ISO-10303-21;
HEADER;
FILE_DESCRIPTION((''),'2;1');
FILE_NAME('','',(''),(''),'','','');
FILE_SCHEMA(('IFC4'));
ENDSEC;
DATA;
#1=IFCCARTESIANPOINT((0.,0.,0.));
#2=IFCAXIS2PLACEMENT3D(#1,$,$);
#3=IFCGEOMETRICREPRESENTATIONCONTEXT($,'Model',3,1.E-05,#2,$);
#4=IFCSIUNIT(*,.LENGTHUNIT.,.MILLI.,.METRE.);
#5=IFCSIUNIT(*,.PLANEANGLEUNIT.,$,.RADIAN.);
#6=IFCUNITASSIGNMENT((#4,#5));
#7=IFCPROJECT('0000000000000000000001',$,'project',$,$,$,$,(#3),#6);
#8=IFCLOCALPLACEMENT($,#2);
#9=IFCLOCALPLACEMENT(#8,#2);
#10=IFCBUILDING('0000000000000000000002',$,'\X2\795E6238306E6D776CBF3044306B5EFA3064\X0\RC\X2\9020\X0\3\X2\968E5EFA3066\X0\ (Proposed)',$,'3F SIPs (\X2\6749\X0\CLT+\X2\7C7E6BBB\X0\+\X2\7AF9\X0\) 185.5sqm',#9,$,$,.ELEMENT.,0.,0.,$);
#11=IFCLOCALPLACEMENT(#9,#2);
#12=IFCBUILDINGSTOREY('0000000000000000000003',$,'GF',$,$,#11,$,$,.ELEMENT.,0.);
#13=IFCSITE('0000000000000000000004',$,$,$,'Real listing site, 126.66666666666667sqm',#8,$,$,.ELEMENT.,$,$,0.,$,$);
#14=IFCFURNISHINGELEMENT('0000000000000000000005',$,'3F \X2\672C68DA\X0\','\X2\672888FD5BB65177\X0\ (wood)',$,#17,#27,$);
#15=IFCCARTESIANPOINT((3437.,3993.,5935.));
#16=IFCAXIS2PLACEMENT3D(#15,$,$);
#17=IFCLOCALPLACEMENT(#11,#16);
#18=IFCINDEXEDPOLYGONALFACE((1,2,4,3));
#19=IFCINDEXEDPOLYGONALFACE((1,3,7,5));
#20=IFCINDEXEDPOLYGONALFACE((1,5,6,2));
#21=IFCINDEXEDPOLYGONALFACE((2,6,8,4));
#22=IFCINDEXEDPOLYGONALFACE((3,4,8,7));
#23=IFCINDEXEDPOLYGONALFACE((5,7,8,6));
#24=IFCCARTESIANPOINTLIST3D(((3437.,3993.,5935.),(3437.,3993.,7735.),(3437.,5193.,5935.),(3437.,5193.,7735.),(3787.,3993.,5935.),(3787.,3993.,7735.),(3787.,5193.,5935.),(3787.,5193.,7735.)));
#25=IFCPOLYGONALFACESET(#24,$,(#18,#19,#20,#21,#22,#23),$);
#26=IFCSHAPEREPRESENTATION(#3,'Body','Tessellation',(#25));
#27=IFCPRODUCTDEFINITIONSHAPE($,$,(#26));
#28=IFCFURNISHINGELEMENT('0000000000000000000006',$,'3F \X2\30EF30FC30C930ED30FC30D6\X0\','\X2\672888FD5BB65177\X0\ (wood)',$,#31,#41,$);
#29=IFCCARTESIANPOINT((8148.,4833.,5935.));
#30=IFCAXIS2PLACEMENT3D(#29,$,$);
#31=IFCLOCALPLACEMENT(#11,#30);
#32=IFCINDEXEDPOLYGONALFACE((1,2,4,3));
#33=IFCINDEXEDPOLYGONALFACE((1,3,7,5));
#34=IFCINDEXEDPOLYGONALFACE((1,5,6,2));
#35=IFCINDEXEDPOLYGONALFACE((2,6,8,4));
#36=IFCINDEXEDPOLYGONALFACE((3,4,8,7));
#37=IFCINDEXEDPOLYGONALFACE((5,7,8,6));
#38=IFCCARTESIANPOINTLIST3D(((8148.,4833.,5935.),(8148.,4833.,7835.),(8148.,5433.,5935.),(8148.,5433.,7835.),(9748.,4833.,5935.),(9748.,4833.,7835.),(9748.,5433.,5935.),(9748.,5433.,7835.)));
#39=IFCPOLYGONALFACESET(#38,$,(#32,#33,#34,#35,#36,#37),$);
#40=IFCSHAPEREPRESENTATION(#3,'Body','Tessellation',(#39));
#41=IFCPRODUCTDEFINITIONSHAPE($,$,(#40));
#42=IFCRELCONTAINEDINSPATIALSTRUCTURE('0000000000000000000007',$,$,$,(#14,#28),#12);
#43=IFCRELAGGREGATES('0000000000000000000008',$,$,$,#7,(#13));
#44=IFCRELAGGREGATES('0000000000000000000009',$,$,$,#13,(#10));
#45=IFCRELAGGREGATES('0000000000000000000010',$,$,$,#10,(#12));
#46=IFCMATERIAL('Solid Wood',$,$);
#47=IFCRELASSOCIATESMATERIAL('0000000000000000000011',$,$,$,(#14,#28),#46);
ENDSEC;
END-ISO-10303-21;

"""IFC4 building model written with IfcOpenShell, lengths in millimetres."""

from ifc_helpers import new_model, si_unit, frame, frame_2d, origin, place, context, project, spatial, rectangle, extrude, material, element, save


model = new_model("IFC4")

# Units and contexts
model_context = context("Model", 3, precision=1e-05, world=origin())
ifc_project = project(units=[si_unit("LENGTHUNIT", "METRE", prefix="MILLI"), si_unit("PLANEANGLEUNIT", "RADIAN")], contexts=[model_context])

# Site, building, storey
site_placement = place(None, origin())
site = spatial("IfcSite", under=ifc_project, at=site_placement, ObjectType="Real listing site, 126.66666666666667sqm", CompositionType="ELEMENT", RefElevation=0.0)
building_placement = place(site_placement, origin())
building = spatial("IfcBuilding", under=site, at=building_placement, Name="神戸の海沿いに建つRC造3階建て (Proposed)", ObjectType="3F SIPs (杉CLT+籾殻+竹) 185.5sqm", CompositionType="ELEMENT", ElevationOfRefHeight=0.0, ElevationOfTerrain=0.0)
storey_placement = place(building_placement, origin())
storey = spatial("IfcBuildingStorey", under=building, at=storey_placement, Name="GF", CompositionType="ELEMENT", Elevation=0.0)

# Shared definitions
ifc_material_1 = material(Name="Solid Wood")

# Furnishing elements
furnishing_1_placement = place(storey_placement, frame((3437.0, 3993.0, 5935.0)))
element("IfcFurnishingElement", 1, at=furnishing_1_placement, inside=storey, material=ifc_material_1, Name="3F 本棚", Description="木製家具 (wood)", context=model_context, shape_type="SweptSolid", body=[
    extrude(rectangle(XDim=350.0, YDim=1200.0, at=frame_2d((175.0, 600.0))), frame((3437.0, 3993.0, 5935.0)), (0.0, 0.0, 1.0), 1800.0),
])
furnishing_2_placement = place(storey_placement, frame((8148.0, 4833.0, 5935.0)))
element("IfcFurnishingElement", 2, at=furnishing_2_placement, inside=storey, material=ifc_material_1, Name="3F ワードローブ", Description="木製家具 (wood)", context=model_context, shape_type="SweptSolid", body=[
    extrude(rectangle(XDim=1600.0, YDim=600.0, at=frame_2d((800.0, 300.0))), frame((8148.0, 4833.0, 5935.0)), (0.0, 0.0, 1.0), 1900.0),
])

save(model, "model.ifc")
